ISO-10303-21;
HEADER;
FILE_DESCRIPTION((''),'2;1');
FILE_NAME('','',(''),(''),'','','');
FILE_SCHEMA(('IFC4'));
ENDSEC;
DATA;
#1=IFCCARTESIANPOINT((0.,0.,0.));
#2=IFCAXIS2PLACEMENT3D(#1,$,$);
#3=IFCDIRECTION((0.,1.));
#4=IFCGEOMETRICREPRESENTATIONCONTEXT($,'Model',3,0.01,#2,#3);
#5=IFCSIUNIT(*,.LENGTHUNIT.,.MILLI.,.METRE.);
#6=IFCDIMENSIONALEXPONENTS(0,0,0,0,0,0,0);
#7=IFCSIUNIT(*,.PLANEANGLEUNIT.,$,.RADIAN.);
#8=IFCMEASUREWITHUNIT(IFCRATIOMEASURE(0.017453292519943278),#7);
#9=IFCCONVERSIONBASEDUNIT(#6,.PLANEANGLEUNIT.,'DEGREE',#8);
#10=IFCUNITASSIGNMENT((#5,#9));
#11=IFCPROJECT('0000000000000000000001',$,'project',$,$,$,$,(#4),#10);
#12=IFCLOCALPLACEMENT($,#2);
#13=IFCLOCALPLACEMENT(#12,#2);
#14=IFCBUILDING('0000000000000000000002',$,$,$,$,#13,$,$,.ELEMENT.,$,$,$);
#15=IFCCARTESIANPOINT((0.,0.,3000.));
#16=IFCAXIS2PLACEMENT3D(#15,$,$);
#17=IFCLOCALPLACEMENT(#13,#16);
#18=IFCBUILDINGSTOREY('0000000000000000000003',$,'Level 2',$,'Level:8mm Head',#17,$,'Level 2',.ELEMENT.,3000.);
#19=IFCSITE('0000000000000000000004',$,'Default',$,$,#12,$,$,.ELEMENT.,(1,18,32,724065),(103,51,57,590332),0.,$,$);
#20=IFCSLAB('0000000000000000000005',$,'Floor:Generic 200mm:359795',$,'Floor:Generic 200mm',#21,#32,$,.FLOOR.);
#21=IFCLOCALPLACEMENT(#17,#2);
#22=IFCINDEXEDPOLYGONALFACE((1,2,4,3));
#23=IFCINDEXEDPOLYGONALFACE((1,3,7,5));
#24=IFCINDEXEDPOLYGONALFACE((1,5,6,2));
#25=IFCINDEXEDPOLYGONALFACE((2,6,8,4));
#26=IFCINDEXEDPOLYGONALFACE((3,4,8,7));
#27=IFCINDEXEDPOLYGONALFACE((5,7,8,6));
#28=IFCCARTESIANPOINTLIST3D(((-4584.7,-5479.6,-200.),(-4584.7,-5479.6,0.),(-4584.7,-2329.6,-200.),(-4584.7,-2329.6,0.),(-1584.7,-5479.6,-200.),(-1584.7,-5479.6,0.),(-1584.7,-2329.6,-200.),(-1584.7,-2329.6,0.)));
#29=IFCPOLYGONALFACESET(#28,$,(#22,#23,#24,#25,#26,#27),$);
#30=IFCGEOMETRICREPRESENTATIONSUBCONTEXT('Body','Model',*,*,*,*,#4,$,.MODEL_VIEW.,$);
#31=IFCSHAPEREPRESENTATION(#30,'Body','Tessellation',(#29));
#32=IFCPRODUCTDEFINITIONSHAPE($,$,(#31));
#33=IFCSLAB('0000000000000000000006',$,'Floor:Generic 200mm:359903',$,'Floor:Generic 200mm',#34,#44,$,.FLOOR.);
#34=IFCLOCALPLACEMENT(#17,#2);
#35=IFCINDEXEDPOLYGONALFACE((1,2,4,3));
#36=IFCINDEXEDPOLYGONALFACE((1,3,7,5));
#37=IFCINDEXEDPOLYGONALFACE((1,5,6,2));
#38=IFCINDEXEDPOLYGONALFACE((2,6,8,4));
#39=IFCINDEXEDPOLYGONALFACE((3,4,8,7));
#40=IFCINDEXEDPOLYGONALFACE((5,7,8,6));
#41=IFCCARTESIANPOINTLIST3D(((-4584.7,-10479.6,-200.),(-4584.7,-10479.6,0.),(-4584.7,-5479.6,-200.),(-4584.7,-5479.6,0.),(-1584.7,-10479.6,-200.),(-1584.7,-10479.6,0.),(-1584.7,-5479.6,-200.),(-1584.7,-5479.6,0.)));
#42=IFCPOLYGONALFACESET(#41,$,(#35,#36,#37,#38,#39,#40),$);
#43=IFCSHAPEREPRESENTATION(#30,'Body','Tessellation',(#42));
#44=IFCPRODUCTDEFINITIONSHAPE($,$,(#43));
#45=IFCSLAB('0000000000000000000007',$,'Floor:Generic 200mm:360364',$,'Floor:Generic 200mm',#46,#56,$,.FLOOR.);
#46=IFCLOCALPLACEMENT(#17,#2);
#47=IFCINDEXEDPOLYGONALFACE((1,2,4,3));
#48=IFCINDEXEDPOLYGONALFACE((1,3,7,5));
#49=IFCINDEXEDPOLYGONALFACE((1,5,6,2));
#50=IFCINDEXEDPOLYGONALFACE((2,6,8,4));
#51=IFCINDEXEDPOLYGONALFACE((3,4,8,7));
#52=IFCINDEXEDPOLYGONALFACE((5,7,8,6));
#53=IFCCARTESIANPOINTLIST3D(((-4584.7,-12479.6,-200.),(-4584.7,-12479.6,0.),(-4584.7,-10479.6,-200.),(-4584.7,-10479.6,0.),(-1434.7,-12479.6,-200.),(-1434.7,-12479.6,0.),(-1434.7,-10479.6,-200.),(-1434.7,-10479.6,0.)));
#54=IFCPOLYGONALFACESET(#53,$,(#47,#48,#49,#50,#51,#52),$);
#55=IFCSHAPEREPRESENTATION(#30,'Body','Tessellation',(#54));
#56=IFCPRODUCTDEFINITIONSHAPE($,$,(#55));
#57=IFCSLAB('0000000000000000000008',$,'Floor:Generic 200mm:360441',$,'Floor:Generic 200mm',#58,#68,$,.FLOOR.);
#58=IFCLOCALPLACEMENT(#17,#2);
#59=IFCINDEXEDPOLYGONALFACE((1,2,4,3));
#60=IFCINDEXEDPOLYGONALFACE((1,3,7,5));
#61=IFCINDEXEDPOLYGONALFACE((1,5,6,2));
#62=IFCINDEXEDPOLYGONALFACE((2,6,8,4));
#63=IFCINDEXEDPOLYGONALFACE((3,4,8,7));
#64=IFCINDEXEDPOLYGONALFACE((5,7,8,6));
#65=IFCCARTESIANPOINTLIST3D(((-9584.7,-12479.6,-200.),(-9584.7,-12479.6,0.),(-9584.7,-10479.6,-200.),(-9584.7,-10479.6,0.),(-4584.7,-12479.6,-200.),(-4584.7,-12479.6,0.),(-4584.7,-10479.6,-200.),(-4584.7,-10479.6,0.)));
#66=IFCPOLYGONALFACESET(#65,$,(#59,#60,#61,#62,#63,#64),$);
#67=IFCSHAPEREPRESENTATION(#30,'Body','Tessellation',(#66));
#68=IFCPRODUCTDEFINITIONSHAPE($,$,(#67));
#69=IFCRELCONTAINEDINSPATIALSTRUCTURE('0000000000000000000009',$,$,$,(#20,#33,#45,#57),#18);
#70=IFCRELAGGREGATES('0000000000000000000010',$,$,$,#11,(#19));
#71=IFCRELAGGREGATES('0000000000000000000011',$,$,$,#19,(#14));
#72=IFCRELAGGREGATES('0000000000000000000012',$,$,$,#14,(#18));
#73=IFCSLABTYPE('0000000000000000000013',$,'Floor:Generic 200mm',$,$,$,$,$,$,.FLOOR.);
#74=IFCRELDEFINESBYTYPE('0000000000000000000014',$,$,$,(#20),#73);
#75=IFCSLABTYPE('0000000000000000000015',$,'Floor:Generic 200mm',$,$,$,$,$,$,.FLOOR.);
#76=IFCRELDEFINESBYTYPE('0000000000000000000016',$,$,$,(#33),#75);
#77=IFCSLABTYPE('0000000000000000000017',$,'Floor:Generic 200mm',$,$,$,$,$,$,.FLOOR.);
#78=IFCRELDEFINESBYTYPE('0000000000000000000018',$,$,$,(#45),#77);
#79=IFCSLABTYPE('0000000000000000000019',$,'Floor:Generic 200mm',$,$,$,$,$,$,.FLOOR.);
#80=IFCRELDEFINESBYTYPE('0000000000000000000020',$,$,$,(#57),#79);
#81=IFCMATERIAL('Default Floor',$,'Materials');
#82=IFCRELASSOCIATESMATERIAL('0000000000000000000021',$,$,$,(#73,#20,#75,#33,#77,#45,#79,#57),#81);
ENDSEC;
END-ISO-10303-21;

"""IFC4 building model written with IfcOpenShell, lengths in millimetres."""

from ifc_helpers import new_model, entity, si_unit, converted_unit, direction, frame, origin, place, context, subcontext, project, spatial, indexed_curve, outline, extrude, material, type_object, element, save


model = new_model("IFC4")

# Units and contexts
model_context = context("Model", 3, precision=0.01, world=origin(), true_north=direction((0.0, 1.0)))
body_context = subcontext(model_context, "Body", "Model", "MODEL_VIEW")
ifc_project = project(units=[si_unit("LENGTHUNIT", "METRE", prefix="MILLI"), converted_unit("PLANEANGLEUNIT", "DEGREE", entity("IfcRatioMeasure", 0.017453292519943278), si_unit("PLANEANGLEUNIT", "RADIAN"), dimensions=[0, 0, 0, 0, 0, 0, 0])], contexts=[model_context])

# Site, building, storey
site_placement = place(None, origin())
site = spatial("IfcSite", under=ifc_project, at=site_placement, Name="Default", CompositionType="ELEMENT", RefLatitude=(1, 18, 32, 724065), RefLongitude=(103, 51, 57, 590332), RefElevation=0.0)
building_placement = place(site_placement, origin())
building = spatial("IfcBuilding", under=site, at=building_placement, CompositionType="ELEMENT")
storey_placement = place(building_placement, frame((0.0, 0.0, 3000.0)))
storey = spatial("IfcBuildingStorey", under=building, at=storey_placement, Name="Level 2", ObjectType="Level:8mm Head", LongName="Level 2", CompositionType="ELEMENT", Elevation=3000.0)

# Slabs
ifc_material_1 = material(Name="Default Floor", Category="Materials")
slab_type_1 = type_object("IfcSlabType", Name="Floor:Generic 200mm", PredefinedType="FLOOR", material=ifc_material_1)
slab_1_placement = place(storey_placement, origin())
element("IfcSlab", 1, at=slab_1_placement, inside=storey, type_object=slab_type_1, material=ifc_material_1, Name="Floor:Generic 200mm:359795", ObjectType="Floor:Generic 200mm", PredefinedType="FLOOR", context=body_context, shape_type="SweptSolid", body=[
    extrude(outline(indexed_curve([(-1575.0, -1500.0), (1575.0, -1500.0), (1575.0, 1500.0), (-1575.0, 1500.0), (-1575.0, -1500.0)], self_intersect=False)), frame((-3084.7, -3904.6, 0.0), z_axis=(0.0, 0.0, -1.0), x_axis=(0.0, 1.0, 0.0)), (0.0, 0.0, 1.0), 200.0),
])
slab_type_2 = type_object("IfcSlabType", Name="Floor:Generic 200mm", PredefinedType="FLOOR", material=ifc_material_1)
slab_2_placement = place(storey_placement, origin())
element("IfcSlab", 2, at=slab_2_placement, inside=storey, type_object=slab_type_2, material=ifc_material_1, Name="Floor:Generic 200mm:359903", ObjectType="Floor:Generic 200mm", PredefinedType="FLOOR", context=body_context, shape_type="SweptSolid", body=[
    extrude(outline(indexed_curve([(-2500.0, -1500.0), (2500.0, -1500.0), (2500.0, 1500.0), (-2500.0, 1500.0), (-2500.0, -1500.0)], self_intersect=False)), frame((-3084.7, -7979.6, 0.0), z_axis=(0.0, 0.0, -1.0), x_axis=(0.0, 1.0, 0.0)), (0.0, 0.0, 1.0), 200.0),
])
slab_type_3 = type_object("IfcSlabType", Name="Floor:Generic 200mm", PredefinedType="FLOOR", material=ifc_material_1)
slab_3_placement = place(storey_placement, origin())
element("IfcSlab", 3, at=slab_3_placement, inside=storey, type_object=slab_type_3, material=ifc_material_1, Name="Floor:Generic 200mm:360364", ObjectType="Floor:Generic 200mm", PredefinedType="FLOOR", context=body_context, shape_type="SweptSolid", body=[
    extrude(outline(indexed_curve([(-1000.0, -1575.0), (1000.0, -1575.0), (1000.0, 1575.0), (-1000.0, 1575.0), (-1000.0, -1575.0)], self_intersect=False)), frame((-3009.7, -11479.6, 0.0), z_axis=(0.0, 0.0, -1.0), x_axis=(0.0, 1.0, 0.0)), (0.0, 0.0, 1.0), 200.0),
])
slab_type_4 = type_object("IfcSlabType", Name="Floor:Generic 200mm", PredefinedType="FLOOR", material=ifc_material_1)
slab_4_placement = place(storey_placement, origin())
element("IfcSlab", 4, at=slab_4_placement, inside=storey, type_object=slab_type_4, material=ifc_material_1, Name="Floor:Generic 200mm:360441", ObjectType="Floor:Generic 200mm", PredefinedType="FLOOR", context=body_context, shape_type="SweptSolid", body=[
    extrude(outline(indexed_curve([(-1000.0, -2500.0), (1000.0, -2500.0), (1000.0, 2500.0), (-1000.0, 2500.0), (-1000.0, -2500.0)], self_intersect=False)), frame((-7084.7, -11479.6, 0.0), z_axis=(0.0, 0.0, -1.0), x_axis=(0.0, 1.0, 0.0)), (0.0, 0.0, 1.0), 200.0),
])

save(model, "model.ifc")
